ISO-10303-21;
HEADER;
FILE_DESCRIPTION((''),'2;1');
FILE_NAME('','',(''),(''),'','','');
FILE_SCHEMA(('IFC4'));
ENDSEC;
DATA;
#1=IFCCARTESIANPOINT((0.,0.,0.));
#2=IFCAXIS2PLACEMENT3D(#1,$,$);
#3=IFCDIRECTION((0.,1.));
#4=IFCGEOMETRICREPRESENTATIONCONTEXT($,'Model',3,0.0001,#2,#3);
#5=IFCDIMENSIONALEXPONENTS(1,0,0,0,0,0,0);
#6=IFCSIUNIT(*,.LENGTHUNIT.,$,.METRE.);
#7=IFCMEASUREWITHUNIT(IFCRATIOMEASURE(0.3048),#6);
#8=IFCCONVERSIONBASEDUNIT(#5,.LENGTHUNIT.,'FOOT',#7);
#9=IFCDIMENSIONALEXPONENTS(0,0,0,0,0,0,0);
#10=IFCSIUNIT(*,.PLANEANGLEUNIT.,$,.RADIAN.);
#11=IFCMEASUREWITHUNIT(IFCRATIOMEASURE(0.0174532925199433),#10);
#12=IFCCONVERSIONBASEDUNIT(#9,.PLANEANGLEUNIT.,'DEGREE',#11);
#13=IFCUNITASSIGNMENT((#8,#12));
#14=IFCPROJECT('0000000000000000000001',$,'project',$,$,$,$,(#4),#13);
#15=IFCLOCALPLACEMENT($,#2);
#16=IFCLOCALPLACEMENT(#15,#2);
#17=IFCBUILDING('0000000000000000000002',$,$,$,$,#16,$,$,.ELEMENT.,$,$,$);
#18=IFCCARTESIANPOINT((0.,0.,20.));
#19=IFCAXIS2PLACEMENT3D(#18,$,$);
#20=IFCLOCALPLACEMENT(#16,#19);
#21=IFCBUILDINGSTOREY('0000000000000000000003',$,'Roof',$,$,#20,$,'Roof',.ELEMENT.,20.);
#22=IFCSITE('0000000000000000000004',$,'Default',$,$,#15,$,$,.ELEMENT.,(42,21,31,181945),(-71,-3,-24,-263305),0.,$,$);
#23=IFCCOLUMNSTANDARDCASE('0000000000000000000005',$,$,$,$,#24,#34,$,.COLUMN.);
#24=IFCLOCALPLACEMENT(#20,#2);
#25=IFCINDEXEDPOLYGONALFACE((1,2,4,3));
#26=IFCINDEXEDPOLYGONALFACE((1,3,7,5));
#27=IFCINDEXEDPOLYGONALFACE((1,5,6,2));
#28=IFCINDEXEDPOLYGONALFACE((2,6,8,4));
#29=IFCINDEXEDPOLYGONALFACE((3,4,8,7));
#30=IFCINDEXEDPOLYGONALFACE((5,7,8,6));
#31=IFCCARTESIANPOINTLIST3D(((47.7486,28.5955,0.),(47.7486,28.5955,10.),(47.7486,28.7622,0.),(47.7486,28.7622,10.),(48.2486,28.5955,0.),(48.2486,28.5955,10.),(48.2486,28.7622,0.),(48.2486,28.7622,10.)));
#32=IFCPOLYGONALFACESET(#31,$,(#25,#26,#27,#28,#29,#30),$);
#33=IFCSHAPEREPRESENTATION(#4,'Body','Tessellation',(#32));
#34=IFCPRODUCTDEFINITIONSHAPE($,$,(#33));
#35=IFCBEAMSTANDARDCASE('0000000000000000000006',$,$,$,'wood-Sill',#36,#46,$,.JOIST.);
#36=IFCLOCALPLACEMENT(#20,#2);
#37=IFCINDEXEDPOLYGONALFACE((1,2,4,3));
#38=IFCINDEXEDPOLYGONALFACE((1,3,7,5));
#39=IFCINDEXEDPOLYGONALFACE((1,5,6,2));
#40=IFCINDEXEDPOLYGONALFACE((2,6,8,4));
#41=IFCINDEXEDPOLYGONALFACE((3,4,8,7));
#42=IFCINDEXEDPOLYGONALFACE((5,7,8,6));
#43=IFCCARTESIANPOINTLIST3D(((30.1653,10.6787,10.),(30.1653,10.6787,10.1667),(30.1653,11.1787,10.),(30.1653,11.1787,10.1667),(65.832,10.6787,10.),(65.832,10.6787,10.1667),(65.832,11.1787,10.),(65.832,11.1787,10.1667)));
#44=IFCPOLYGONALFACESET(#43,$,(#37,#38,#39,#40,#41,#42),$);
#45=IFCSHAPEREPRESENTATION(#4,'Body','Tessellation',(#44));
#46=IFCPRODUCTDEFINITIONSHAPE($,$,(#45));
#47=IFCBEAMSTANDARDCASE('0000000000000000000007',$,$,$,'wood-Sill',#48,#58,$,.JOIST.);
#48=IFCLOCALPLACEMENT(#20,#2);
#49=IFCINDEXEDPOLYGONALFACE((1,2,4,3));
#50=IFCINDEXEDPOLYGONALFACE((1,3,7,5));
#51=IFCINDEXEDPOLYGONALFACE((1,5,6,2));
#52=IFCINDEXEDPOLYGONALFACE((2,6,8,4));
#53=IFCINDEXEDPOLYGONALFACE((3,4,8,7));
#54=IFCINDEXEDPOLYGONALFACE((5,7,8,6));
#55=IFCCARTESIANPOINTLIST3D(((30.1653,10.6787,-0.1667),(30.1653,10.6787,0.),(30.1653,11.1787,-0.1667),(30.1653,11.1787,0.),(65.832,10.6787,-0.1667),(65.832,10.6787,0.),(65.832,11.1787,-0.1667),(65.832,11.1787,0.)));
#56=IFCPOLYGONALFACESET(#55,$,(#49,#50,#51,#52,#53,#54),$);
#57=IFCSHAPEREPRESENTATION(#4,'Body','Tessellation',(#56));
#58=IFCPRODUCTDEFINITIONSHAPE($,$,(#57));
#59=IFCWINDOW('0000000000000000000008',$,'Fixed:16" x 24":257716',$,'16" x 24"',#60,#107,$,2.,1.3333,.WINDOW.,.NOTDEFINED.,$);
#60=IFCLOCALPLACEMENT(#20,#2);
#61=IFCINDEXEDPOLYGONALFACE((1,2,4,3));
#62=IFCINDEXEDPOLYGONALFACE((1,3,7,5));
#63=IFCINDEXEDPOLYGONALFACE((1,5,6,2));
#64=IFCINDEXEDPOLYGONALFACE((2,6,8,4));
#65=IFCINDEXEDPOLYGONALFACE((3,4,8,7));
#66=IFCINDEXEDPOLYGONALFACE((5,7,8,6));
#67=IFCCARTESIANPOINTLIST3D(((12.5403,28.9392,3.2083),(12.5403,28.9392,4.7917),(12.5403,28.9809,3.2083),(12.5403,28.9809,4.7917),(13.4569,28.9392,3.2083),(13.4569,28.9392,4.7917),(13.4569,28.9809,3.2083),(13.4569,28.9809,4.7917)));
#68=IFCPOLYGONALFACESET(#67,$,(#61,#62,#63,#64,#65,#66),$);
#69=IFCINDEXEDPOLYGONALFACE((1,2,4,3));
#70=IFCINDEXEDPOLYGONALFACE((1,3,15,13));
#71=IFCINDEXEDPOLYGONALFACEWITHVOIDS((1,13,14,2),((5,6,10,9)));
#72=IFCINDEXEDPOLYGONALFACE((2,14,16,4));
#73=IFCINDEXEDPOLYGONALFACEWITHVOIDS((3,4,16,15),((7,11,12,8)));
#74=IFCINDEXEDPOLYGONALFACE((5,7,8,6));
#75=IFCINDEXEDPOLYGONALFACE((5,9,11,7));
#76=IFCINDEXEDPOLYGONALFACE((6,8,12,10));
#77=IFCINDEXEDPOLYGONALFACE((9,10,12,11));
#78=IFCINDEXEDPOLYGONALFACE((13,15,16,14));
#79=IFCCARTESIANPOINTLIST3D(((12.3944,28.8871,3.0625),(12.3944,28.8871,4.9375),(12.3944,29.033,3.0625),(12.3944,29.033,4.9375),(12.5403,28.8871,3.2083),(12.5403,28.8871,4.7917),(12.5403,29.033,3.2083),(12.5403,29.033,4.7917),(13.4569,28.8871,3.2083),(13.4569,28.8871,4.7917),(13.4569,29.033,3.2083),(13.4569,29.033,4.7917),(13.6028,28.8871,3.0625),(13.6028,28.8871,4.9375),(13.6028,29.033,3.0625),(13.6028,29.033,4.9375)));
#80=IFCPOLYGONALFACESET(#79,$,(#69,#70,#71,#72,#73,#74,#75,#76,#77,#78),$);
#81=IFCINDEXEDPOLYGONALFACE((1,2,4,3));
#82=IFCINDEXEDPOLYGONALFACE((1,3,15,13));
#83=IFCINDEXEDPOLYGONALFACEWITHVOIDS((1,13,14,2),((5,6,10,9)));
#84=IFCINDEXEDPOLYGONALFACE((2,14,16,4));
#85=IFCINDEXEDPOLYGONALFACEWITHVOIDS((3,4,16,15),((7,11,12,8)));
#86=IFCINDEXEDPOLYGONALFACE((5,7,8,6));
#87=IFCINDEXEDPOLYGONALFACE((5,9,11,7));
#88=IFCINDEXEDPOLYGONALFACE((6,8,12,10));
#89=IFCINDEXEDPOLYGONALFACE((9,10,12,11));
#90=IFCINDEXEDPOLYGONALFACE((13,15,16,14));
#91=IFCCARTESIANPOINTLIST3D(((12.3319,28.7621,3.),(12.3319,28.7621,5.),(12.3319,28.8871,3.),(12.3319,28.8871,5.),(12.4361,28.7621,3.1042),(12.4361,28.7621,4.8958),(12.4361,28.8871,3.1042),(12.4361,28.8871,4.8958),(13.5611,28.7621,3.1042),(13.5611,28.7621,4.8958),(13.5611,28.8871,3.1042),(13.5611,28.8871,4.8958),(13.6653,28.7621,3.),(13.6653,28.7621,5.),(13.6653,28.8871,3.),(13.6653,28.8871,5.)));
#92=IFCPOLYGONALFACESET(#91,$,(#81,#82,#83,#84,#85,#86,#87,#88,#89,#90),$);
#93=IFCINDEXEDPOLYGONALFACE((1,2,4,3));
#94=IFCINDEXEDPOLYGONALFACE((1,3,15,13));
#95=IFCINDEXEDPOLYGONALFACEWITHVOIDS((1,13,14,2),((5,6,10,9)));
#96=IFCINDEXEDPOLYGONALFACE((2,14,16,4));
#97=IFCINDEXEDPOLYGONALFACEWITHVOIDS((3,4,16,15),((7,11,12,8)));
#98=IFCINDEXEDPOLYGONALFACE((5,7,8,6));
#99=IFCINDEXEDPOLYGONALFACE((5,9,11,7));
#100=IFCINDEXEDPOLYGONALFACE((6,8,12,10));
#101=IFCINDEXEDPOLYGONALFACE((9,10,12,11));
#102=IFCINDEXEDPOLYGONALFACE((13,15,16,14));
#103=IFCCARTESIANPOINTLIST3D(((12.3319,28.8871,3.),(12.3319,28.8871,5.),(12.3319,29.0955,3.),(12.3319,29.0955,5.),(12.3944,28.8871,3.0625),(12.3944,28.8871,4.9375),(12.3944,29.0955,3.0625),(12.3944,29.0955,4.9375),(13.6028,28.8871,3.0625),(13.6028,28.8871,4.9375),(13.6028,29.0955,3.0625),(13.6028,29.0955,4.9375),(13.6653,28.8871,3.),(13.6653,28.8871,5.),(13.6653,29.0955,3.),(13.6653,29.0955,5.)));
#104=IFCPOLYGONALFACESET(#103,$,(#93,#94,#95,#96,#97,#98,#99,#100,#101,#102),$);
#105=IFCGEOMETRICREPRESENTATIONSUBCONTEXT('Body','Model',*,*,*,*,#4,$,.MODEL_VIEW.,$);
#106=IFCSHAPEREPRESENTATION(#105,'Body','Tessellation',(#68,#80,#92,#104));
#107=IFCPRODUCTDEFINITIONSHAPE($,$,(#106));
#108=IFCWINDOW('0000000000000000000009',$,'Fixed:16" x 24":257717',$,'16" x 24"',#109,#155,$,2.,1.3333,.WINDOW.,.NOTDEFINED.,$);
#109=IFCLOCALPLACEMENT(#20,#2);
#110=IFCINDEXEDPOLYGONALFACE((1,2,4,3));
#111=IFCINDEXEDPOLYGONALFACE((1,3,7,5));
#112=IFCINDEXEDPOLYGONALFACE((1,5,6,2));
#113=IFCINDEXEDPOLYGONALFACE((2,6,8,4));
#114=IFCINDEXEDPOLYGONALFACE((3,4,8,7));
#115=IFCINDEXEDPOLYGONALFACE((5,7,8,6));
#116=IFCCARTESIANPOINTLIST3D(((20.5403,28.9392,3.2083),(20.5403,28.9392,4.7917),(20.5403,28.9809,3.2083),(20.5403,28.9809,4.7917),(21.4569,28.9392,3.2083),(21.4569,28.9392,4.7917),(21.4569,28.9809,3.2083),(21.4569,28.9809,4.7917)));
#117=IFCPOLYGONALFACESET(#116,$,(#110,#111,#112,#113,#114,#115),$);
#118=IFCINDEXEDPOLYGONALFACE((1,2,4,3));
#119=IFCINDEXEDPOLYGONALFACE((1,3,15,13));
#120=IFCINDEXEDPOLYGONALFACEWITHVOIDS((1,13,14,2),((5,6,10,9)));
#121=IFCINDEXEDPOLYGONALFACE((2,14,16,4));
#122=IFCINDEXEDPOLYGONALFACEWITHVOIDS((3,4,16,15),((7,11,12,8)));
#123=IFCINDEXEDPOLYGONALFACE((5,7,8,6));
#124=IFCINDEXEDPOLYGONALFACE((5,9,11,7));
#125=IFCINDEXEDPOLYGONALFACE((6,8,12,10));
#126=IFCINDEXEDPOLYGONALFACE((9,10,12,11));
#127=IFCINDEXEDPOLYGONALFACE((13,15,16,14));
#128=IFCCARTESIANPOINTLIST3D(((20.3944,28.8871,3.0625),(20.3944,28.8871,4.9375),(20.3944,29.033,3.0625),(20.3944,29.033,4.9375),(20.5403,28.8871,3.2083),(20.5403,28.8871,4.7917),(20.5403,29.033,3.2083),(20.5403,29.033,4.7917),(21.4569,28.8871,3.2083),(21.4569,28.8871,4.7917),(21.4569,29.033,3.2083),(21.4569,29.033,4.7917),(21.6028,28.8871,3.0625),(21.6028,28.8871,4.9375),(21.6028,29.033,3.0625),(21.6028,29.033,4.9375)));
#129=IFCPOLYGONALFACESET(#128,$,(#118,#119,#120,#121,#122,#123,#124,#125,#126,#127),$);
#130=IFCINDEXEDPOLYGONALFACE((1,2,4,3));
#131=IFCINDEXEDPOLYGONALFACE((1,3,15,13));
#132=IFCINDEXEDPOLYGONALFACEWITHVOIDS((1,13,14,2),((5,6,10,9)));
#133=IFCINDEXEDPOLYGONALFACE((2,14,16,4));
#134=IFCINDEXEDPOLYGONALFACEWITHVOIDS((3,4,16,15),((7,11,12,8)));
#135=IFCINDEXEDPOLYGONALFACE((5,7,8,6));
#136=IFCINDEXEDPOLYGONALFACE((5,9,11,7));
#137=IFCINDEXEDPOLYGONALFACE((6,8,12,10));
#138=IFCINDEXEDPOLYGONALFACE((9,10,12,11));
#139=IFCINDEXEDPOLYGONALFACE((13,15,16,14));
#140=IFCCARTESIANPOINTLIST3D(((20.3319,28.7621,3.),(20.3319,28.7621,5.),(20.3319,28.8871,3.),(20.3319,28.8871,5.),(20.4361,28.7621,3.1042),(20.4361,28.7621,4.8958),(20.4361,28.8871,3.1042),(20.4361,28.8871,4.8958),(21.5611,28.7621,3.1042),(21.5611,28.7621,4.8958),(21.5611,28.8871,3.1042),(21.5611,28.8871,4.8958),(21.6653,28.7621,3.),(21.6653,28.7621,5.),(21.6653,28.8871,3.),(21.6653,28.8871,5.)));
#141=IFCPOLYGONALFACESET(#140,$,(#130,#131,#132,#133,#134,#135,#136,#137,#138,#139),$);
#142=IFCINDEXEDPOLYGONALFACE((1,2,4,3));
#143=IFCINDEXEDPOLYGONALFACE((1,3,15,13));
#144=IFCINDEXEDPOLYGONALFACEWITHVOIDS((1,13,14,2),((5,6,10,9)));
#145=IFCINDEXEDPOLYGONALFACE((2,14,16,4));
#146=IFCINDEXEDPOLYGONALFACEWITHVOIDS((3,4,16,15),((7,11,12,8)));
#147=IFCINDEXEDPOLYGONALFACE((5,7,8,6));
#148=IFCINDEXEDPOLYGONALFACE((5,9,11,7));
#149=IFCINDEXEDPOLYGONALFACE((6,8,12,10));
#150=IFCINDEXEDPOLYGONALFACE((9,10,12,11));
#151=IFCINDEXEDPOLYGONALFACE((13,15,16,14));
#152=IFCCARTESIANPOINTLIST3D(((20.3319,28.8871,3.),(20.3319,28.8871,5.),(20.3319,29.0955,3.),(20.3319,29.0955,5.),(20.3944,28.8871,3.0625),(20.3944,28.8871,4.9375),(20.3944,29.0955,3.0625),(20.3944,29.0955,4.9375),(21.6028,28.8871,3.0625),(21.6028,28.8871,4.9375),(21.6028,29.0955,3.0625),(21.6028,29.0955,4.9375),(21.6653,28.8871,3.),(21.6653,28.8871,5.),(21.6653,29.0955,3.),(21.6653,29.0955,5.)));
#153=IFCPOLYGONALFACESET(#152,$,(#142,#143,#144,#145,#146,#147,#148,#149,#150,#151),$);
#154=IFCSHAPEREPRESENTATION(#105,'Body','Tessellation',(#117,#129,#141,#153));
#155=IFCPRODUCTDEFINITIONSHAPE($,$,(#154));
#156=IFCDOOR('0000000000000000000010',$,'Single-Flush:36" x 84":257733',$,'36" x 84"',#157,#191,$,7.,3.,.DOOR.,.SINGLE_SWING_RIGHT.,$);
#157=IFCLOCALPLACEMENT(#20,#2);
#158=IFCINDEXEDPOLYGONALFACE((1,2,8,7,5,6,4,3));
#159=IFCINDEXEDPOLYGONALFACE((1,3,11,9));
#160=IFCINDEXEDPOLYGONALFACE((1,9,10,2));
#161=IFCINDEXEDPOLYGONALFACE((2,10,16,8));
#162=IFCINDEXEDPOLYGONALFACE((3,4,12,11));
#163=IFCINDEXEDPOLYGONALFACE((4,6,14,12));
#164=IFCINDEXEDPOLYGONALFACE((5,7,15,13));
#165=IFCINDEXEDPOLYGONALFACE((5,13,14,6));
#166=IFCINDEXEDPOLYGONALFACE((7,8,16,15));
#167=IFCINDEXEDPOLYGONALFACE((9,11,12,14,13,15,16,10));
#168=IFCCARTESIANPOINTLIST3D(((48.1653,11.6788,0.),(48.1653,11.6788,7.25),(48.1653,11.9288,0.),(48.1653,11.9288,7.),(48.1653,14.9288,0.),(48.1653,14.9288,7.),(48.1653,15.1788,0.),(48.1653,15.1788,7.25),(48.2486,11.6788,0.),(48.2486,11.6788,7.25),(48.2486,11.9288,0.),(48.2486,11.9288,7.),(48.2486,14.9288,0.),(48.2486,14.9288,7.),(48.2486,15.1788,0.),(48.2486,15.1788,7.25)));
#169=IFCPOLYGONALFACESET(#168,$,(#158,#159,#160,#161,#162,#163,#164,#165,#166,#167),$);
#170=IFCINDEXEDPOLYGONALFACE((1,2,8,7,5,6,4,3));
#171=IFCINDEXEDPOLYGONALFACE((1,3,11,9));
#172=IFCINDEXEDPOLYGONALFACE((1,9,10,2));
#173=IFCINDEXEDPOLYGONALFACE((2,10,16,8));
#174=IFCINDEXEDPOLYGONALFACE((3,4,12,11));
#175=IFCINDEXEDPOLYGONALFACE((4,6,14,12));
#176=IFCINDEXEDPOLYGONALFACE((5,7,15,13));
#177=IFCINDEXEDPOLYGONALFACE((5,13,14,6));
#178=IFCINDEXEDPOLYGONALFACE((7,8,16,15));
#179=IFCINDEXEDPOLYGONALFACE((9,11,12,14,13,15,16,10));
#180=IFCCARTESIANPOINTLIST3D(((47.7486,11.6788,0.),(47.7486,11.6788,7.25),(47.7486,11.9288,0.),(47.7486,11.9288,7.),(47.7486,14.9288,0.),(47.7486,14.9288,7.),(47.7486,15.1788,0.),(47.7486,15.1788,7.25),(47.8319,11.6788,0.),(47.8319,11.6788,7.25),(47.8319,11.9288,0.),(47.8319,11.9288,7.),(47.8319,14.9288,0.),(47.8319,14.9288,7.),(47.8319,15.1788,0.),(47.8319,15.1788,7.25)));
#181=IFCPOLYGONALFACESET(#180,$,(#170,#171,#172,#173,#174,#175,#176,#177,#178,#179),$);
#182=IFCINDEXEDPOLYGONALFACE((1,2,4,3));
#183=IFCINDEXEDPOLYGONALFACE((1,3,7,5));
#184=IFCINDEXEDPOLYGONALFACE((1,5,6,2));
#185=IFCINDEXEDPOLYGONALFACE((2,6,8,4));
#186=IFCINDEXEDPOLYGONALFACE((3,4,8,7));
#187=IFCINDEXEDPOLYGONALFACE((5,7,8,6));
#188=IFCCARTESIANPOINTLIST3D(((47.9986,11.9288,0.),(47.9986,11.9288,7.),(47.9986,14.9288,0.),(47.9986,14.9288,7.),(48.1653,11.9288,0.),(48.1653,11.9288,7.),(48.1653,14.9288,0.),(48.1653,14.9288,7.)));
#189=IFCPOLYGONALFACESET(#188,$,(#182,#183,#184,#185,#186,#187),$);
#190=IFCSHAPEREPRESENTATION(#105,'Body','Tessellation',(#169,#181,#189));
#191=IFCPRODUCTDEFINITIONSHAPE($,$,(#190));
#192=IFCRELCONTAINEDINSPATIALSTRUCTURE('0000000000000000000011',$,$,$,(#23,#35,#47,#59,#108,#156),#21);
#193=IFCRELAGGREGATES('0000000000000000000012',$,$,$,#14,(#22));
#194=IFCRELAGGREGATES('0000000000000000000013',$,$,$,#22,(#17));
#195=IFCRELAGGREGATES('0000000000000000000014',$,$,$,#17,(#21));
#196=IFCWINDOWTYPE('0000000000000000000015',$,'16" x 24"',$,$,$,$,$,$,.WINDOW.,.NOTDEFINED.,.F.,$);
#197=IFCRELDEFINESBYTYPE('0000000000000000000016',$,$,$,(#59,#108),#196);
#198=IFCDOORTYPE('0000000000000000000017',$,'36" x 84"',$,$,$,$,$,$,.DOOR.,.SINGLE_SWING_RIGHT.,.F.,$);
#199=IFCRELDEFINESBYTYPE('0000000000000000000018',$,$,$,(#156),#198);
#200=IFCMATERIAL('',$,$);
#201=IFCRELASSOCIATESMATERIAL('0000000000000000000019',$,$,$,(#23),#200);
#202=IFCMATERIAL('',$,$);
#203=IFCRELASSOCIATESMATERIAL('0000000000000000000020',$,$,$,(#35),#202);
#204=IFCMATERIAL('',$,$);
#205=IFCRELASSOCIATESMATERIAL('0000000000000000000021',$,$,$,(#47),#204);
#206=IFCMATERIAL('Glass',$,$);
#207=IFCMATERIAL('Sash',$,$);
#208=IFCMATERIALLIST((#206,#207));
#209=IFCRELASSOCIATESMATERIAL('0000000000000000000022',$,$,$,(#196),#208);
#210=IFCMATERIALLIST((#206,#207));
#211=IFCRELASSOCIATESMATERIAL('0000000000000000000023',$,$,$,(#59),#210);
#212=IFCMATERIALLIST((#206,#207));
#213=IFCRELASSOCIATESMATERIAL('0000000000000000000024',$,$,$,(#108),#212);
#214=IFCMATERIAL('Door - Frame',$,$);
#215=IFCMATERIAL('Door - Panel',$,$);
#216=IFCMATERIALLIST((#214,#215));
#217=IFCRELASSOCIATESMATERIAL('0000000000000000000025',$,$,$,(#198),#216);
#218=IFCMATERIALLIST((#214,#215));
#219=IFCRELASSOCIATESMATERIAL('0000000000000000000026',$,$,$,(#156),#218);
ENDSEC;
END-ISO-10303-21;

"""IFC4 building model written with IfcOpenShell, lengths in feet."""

from ifc_helpers import new_model, entity, si_unit, converted_unit, direction, frame, frame_2d, origin, origin_2d_with_axis, place, context, subcontext, project, spatial, polyline, rectangle, outline, extrude, source, transform, mapped, material, material_list, type_object, type_shapes, element, save


model = new_model("IFC4")

# Units and contexts
model_context = context("Model", 3, precision=0.0001, world=origin(), true_north=direction((0.0, 1.0)))
body_context = subcontext(model_context, "Body", "Model", "MODEL_VIEW")
ifc_project = project(units=[converted_unit("LENGTHUNIT", "FOOT", entity("IfcRatioMeasure", 0.3048), si_unit("LENGTHUNIT", "METRE"), dimensions=[1, 0, 0, 0, 0, 0, 0]), converted_unit("PLANEANGLEUNIT", "DEGREE", entity("IfcRatioMeasure", 0.0174532925199433), si_unit("PLANEANGLEUNIT", "RADIAN"), dimensions=[0, 0, 0, 0, 0, 0, 0])], contexts=[model_context])

# Site, building, storey
site_placement = place(None, origin())
site = spatial("IfcSite", under=ifc_project, at=site_placement, Name="Default", CompositionType="ELEMENT", RefLatitude=(42, 21, 31, 181945), RefLongitude=(-71, -3, -24, -263305), RefElevation=0.0)
building_placement = place(site_placement, origin())
building = spatial("IfcBuilding", under=site, at=building_placement, CompositionType="ELEMENT")
storey_placement = place(building_placement, frame((0.0, 0.0, 20.0)))
storey = spatial("IfcBuildingStorey", under=building, at=storey_placement, Name="Roof", LongName="Roof", CompositionType="ELEMENT", Elevation=20.0)

# Column
placement_1 = place(storey_placement, frame((-0.1681, 28.9288, 0.0)))
ifc_material_1 = material(Name="")
placement_2 = place(storey_placement, frame((47.9986, 28.7621, 0.0), z_axis=(0.0, 0.0, 1.0), x_axis=(0.0, -1.0, 0.0)))
for number, where, z_axis, x_axis in (
    (1, (0.0833, 0.0, 0.0), (0.0, 0.0, 1.0), (1.0, 0.0, 0.0)),
):
    element("IfcColumnStandardCase", number, at=place(placement_2, frame(where, z_axis=z_axis, x_axis=x_axis)), inside=storey, material=ifc_material_1, PredefinedType="COLUMN", context=model_context, shape_type="SweptSolid", body=[
        extrude(rectangle(XDim=0.1667, YDim=0.5), origin(), (0.0, 0.0, 1.0), 10.0),
    ])

# Beams
ifc_material_2 = material(Name="")
beam_1_placement = place(placement_2, frame((17.8334, 0.0, 10.0), z_axis=(0.0, 0.0, 1.0), x_axis=(0.0, -1.0, 0.0)))
element("IfcBeamStandardCase", 2, at=beam_1_placement, inside=storey, material=ifc_material_2, ObjectType="wood-Sill", PredefinedType="JOIST", context=model_context, shape_type="SweptSolid", body=[
    extrude(rectangle(XDim=35.6667, YDim=0.5), origin(), (0.0, 0.0, 1.0), 0.1667),
])
ifc_material_3 = material(Name="")
beam_2_placement = place(placement_2, frame((17.8334, 0.0, -0.1667), z_axis=(0.0, 0.0, 1.0), x_axis=(0.0, -1.0, 0.0)))
element("IfcBeamStandardCase", 3, at=beam_2_placement, inside=storey, material=ifc_material_3, ObjectType="wood-Sill", PredefinedType="JOIST", context=model_context, shape_type="SweptSolid", body=[
    extrude(rectangle(XDim=35.6667, YDim=0.5), origin(), (0.0, 0.0, 1.0), 0.1667),
])

# Windows
ifc_material_4 = material(Name="Glass")
ifc_material_5 = material(Name="Sash")
ifc_material_list_1 = material_list([ifc_material_4, ifc_material_5])
ifc_material_list_2 = material_list([ifc_material_4, ifc_material_5])
window_type = type_object("IfcWindowType", Name="16\" x 24\"", ParameterTakesPrecedence=False, PartitioningType="NOTDEFINED", PredefinedType="WINDOW", material=ifc_material_list_2)
shared_shape_1 = source(origin(), body_context, "Body", "SweptSolid", [
    extrude(rectangle(XDim=0.0417, YDim=0.9167, at=origin_2d_with_axis()), frame((0.6667, 0.1979, 0.2083), z_axis=(0.0, 0.0, 1.0), x_axis=(0.0, 1.0, 0.0)), (0.0, 0.0, 1.0), 1.5833),
    extrude(outline(polyline([(-0.6042, -0.9375), (0.6042, -0.9375), (0.6042, 0.9375), (-0.6042, 0.9375), (-0.6042, -0.9375)]), holes=[polyline([(-0.4583, -0.7917), (-0.4583, 0.7917), (0.4583, 0.7917), (0.4583, -0.7917), (-0.4583, -0.7917)])]), frame((0.6667, 0.125, 1.0), z_axis=(0.0, 1.0, 0.0), x_axis=(1.0, 0.0, 0.0)), (0.0, 0.0, 1.0), 0.1458),
    extrude(outline(polyline([(-0.6667, -1.0), (0.6667, -1.0), (0.6667, 1.0), (-0.6667, 1.0), (-0.6667, -1.0)]), holes=[polyline([(-0.5625, -0.8958), (-0.5625, 0.8958), (0.5625, 0.8958), (0.5625, -0.8958), (-0.5625, -0.8958)])]), frame((0.6667, 0.0, 1.0), z_axis=(0.0, 1.0, 0.0), x_axis=(1.0, 0.0, 0.0)), (0.0, 0.0, 1.0), 0.125),
    extrude(outline(polyline([(-1.0, -0.6667), (1.0, -0.6667), (1.0, 0.6667), (-1.0, 0.6667), (-1.0, -0.6667)]), holes=[polyline([(-0.9375, -0.6042), (-0.9375, 0.6042), (0.9375, 0.6042), (0.9375, -0.6042), (-0.9375, -0.6042)])]), frame((0.6667, 0.125, 1.0), z_axis=(0.0, 1.0, 0.0), x_axis=(0.0, 0.0, -1.0)), (0.0, 0.0, 1.0), 0.2083),
])
type_shapes(window_type, [shared_shape_1])
placement_3 = place(placement_1, frame((12.5, -0.1667, 3.0)))
window_1_placement = place(placement_3, origin())
element("IfcWindow", 4, at=window_1_placement, inside=storey, type_object=window_type, material=ifc_material_list_1, Name="Fixed:16\" x 24\":257716", ObjectType="16\" x 24\"", OverallHeight=2.0, OverallWidth=1.3333, PartitioningType="NOTDEFINED", PredefinedType="WINDOW", context=body_context, shape_type="MappedRepresentation", body=[
    mapped(shared_shape_1, transform((0.0, 0.0, 0.0), scale=1.0)),
])
ifc_material_list_3 = material_list([ifc_material_4, ifc_material_5])
placement_4 = place(placement_1, frame((20.5, -0.1667, 3.0)))
window_2_placement = place(placement_4, origin())
element("IfcWindow", 5, at=window_2_placement, inside=storey, type_object=window_type, material=ifc_material_list_3, Name="Fixed:16\" x 24\":257717", ObjectType="16\" x 24\"", OverallHeight=2.0, OverallWidth=1.3333, PartitioningType="NOTDEFINED", PredefinedType="WINDOW", context=body_context, shape_type="MappedRepresentation", body=[
    mapped(shared_shape_1, transform((0.0, 0.0, 0.0), scale=1.0)),
])

# Door
ifc_material_6 = material(Name="Door - Frame")
ifc_material_7 = material(Name="Door - Panel")
ifc_material_list_4 = material_list([ifc_material_6, ifc_material_7])
ifc_material_list_5 = material_list([ifc_material_6, ifc_material_7])
door_type = type_object("IfcDoorType", Name="36\" x 84\"", OperationType="SINGLE_SWING_RIGHT", ParameterTakesPrecedence=False, PredefinedType="DOOR", material=ifc_material_list_5)
shared_shape_2 = source(origin(), body_context, "Body", "SweptSolid", [
    extrude(outline(polyline([(-1.75, -3.6875), (1.75, -3.6875), (1.75, 3.5625), (1.5, 3.5625), (1.5, -3.4375), (-1.5, -3.4375), (-1.5, 3.5625), (-1.75, 3.5625), (-1.75, -3.6875)])), frame((1.5, 0.3333, 3.5625), z_axis=(0.0, 1.0, 0.0), x_axis=(1.0, 0.0, 0.0)), (0.0, 0.0, 1.0), 0.0833),
    extrude(outline(polyline([(-3.6875, -1.75), (3.5625, -1.75), (3.5625, -1.5), (-3.4375, -1.5), (-3.4375, 1.5), (3.5625, 1.5), (3.5625, 1.75), (-3.6875, 1.75), (-3.6875, -1.75)])), frame((1.5, -0.0833, 3.5625), z_axis=(0.0, 1.0, 0.0), x_axis=(0.0, 0.0, -1.0)), (0.0, 0.0, 1.0), 0.0833),
    extrude(rectangle(XDim=0.1667, YDim=3.0, at=frame_2d((0.0, 0.0), x_axis=(1.0, 0.0))), frame((1.5, 0.25, 0.0), z_axis=(0.0, 0.0, 1.0), x_axis=(0.0, 1.0, 0.0)), (0.0, 0.0, 1.0), 7.0),
])
type_shapes(door_type, [shared_shape_2])
placement_5 = place(placement_2, frame((13.8333, -0.1667, 0.0)))
door_placement = place(placement_5, origin())
element("IfcDoor", 6, at=door_placement, inside=storey, type_object=door_type, material=ifc_material_list_4, Name="Single-Flush:36\" x 84\":257733", ObjectType="36\" x 84\"", OperationType="SINGLE_SWING_RIGHT", OverallHeight=7.0, OverallWidth=3.0, PredefinedType="DOOR", context=body_context, shape_type="MappedRepresentation", body=[
    mapped(shared_shape_2, transform((0.0, 0.0, 0.0), scale=1.0)),
])

save(model, "model.ifc")
